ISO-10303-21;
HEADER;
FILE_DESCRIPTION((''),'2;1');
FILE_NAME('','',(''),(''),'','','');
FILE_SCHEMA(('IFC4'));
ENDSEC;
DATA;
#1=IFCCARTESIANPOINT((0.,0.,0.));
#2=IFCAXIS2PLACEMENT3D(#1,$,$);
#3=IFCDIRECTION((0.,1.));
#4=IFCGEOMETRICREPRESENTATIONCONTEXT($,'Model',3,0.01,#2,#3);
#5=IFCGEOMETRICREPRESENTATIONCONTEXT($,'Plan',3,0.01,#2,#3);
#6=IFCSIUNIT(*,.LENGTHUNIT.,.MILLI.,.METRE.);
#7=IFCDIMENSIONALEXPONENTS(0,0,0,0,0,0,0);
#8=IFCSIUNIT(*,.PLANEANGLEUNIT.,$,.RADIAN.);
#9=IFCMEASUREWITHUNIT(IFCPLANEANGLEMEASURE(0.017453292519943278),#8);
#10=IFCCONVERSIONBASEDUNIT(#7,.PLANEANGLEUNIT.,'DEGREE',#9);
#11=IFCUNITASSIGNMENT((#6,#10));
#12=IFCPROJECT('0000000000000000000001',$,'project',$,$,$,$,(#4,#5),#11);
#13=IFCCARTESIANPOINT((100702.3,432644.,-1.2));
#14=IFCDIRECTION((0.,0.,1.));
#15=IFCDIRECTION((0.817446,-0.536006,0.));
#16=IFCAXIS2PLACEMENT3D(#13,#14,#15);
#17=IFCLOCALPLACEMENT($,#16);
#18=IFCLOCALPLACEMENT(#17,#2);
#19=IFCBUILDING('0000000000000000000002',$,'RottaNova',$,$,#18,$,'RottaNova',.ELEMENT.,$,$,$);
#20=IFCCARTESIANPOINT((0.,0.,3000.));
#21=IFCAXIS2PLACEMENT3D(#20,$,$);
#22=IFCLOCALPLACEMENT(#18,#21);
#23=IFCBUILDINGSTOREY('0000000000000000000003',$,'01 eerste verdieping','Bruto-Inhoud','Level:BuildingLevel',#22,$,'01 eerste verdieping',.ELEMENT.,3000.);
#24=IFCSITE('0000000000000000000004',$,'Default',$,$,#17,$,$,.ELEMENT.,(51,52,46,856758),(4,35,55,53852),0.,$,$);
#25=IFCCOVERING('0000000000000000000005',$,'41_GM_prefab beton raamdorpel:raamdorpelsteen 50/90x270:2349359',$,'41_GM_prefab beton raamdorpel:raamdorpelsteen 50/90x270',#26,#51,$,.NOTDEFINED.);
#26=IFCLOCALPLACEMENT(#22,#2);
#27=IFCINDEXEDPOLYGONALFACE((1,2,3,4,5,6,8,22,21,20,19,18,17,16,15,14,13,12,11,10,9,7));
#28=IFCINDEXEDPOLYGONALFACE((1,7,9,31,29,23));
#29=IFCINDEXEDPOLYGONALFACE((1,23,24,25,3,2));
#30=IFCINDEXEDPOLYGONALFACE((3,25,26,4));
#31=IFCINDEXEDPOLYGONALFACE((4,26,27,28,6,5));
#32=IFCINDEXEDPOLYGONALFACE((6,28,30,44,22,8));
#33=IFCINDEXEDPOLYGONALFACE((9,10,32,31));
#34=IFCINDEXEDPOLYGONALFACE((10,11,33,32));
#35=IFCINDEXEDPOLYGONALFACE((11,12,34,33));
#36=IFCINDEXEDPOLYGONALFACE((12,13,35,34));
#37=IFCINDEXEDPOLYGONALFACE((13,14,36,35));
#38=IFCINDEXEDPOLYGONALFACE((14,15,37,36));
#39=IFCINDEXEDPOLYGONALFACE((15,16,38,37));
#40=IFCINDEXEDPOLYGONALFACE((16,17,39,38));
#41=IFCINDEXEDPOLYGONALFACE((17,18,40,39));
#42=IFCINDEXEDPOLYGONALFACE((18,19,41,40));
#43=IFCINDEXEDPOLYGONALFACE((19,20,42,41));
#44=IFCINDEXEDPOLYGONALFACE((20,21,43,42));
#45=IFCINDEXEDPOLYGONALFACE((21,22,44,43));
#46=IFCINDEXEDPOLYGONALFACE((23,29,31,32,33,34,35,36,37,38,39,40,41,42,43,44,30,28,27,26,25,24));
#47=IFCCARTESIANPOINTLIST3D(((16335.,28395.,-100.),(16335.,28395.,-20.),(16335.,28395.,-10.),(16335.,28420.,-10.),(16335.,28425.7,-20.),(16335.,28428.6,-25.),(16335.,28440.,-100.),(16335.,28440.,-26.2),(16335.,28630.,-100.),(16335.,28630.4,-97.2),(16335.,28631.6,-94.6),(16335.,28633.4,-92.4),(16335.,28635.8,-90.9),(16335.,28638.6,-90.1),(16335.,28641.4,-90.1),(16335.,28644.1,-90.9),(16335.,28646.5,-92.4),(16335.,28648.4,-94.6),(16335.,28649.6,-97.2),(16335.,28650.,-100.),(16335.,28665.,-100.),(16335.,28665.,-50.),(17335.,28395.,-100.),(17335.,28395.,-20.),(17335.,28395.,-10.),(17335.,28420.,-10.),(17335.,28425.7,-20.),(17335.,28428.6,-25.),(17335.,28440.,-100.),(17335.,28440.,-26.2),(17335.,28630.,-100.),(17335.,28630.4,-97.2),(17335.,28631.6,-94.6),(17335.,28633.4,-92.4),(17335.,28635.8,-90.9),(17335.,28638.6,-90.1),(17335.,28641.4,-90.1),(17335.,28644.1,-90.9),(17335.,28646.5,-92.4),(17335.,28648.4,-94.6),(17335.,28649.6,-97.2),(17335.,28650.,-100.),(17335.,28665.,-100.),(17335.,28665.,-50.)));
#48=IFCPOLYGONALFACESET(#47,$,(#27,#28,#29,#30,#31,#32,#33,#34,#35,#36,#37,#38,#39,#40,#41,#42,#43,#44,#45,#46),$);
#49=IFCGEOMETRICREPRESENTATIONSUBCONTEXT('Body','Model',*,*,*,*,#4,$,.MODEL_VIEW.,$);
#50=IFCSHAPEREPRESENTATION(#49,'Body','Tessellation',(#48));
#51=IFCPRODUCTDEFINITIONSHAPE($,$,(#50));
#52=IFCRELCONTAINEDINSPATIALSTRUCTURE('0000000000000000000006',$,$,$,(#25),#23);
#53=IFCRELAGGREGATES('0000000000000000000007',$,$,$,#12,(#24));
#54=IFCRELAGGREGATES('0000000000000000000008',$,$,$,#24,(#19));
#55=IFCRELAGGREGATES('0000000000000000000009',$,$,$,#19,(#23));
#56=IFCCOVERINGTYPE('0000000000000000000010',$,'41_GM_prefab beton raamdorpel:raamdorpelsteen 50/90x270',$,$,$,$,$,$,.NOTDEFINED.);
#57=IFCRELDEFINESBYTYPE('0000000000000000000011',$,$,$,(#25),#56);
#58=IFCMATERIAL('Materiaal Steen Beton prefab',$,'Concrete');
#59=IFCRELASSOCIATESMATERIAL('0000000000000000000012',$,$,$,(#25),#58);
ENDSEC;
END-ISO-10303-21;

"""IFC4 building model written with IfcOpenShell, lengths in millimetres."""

from ifc_helpers import new_model, entity, si_unit, converted_unit, direction, frame, origin, place, context, subcontext, project, spatial, line, arc, indexed_curve, outline, extrude, material, type_object, element, save


model = new_model("IFC4")

# Units and contexts
model_context = context("Model", 3, precision=0.01, world=origin(), true_north=direction((0.0, 1.0)))
plan_context = context("Plan", 3, precision=0.01, world=origin(), true_north=direction((0.0, 1.0)))
body_context = subcontext(model_context, "Body", "Model", "MODEL_VIEW")
ifc_project = project(units=[si_unit("LENGTHUNIT", "METRE", prefix="MILLI"), converted_unit("PLANEANGLEUNIT", "DEGREE", entity("IfcPlaneAngleMeasure", 0.017453292519943278), si_unit("PLANEANGLEUNIT", "RADIAN"), dimensions=[0, 0, 0, 0, 0, 0, 0])], contexts=[model_context, plan_context])

# Site, building, storey
site_placement = place(None, frame((100702.3, 432644.0, -1.2), z_axis=(0.0, 0.0, 1.0), x_axis=(0.817446, -0.536006, 0.0)))
site = spatial("IfcSite", under=ifc_project, at=site_placement, Name="Default", CompositionType="ELEMENT", RefLatitude=(51, 52, 46, 856758), RefLongitude=(4, 35, 55, 53852), RefElevation=0.0)
building_placement = place(site_placement, origin())
building = spatial("IfcBuilding", under=site, at=building_placement, Name="RottaNova", LongName="RottaNova", CompositionType="ELEMENT")
storey_placement = place(building_placement, frame((0.0, 0.0, 3000.0)))
storey = spatial("IfcBuildingStorey", under=building, at=storey_placement, Name="01 eerste verdieping", Description="Bruto-Inhoud", ObjectType="Level:BuildingLevel", LongName="01 eerste verdieping", CompositionType="ELEMENT", Elevation=3000.0)

# Shared definitions
ifc_material_1 = material(Name="Materiaal Steen Beton prefab", Category="Concrete")

# Covering
covering_type_1 = type_object("IfcCoveringType", Name="41_GM_prefab beton raamdorpel:raamdorpelsteen 50/90x270", PredefinedType="NOTDEFINED")
covering_1_placement = place(storey_placement, origin())
element("IfcCovering", 1, at=covering_1_placement, inside=storey, type_object=covering_type_1, material=ifc_material_1, Name="41_GM_prefab beton raamdorpel:raamdorpelsteen 50/90x270:2349359", ObjectType="41_GM_prefab beton raamdorpel:raamdorpelsteen 50/90x270", PredefinedType="NOTDEFINED", context=body_context, shape_type="SweptSolid", body=[
    extrude(outline(indexed_curve([(75.8, -45.1), (100.8, -45.1), (100.8, -35.1), (100.8, 44.9), (55.8, 44.9), (-134.2, 44.9), (-144.2, 34.9), (-154.2, 44.9), (-169.2, 44.9), (-169.2, -5.1), (55.8, -28.9), (67.1, -30.1), (70.0, -35.1)], segments=[line(1, 2, 3, 4, 5, 6), arc(6, 7, 8), line(8, 9, 10, 11, 12, 13, 1)], self_intersect=False)), frame((16335.0, 28495.8, -55.1), z_axis=(1.0, 0.0, 0.0), x_axis=(0.0, -1.0, 0.0)), (0.0, 0.0, 1.0), 1000.0),
])

save(model, "model.ifc")
